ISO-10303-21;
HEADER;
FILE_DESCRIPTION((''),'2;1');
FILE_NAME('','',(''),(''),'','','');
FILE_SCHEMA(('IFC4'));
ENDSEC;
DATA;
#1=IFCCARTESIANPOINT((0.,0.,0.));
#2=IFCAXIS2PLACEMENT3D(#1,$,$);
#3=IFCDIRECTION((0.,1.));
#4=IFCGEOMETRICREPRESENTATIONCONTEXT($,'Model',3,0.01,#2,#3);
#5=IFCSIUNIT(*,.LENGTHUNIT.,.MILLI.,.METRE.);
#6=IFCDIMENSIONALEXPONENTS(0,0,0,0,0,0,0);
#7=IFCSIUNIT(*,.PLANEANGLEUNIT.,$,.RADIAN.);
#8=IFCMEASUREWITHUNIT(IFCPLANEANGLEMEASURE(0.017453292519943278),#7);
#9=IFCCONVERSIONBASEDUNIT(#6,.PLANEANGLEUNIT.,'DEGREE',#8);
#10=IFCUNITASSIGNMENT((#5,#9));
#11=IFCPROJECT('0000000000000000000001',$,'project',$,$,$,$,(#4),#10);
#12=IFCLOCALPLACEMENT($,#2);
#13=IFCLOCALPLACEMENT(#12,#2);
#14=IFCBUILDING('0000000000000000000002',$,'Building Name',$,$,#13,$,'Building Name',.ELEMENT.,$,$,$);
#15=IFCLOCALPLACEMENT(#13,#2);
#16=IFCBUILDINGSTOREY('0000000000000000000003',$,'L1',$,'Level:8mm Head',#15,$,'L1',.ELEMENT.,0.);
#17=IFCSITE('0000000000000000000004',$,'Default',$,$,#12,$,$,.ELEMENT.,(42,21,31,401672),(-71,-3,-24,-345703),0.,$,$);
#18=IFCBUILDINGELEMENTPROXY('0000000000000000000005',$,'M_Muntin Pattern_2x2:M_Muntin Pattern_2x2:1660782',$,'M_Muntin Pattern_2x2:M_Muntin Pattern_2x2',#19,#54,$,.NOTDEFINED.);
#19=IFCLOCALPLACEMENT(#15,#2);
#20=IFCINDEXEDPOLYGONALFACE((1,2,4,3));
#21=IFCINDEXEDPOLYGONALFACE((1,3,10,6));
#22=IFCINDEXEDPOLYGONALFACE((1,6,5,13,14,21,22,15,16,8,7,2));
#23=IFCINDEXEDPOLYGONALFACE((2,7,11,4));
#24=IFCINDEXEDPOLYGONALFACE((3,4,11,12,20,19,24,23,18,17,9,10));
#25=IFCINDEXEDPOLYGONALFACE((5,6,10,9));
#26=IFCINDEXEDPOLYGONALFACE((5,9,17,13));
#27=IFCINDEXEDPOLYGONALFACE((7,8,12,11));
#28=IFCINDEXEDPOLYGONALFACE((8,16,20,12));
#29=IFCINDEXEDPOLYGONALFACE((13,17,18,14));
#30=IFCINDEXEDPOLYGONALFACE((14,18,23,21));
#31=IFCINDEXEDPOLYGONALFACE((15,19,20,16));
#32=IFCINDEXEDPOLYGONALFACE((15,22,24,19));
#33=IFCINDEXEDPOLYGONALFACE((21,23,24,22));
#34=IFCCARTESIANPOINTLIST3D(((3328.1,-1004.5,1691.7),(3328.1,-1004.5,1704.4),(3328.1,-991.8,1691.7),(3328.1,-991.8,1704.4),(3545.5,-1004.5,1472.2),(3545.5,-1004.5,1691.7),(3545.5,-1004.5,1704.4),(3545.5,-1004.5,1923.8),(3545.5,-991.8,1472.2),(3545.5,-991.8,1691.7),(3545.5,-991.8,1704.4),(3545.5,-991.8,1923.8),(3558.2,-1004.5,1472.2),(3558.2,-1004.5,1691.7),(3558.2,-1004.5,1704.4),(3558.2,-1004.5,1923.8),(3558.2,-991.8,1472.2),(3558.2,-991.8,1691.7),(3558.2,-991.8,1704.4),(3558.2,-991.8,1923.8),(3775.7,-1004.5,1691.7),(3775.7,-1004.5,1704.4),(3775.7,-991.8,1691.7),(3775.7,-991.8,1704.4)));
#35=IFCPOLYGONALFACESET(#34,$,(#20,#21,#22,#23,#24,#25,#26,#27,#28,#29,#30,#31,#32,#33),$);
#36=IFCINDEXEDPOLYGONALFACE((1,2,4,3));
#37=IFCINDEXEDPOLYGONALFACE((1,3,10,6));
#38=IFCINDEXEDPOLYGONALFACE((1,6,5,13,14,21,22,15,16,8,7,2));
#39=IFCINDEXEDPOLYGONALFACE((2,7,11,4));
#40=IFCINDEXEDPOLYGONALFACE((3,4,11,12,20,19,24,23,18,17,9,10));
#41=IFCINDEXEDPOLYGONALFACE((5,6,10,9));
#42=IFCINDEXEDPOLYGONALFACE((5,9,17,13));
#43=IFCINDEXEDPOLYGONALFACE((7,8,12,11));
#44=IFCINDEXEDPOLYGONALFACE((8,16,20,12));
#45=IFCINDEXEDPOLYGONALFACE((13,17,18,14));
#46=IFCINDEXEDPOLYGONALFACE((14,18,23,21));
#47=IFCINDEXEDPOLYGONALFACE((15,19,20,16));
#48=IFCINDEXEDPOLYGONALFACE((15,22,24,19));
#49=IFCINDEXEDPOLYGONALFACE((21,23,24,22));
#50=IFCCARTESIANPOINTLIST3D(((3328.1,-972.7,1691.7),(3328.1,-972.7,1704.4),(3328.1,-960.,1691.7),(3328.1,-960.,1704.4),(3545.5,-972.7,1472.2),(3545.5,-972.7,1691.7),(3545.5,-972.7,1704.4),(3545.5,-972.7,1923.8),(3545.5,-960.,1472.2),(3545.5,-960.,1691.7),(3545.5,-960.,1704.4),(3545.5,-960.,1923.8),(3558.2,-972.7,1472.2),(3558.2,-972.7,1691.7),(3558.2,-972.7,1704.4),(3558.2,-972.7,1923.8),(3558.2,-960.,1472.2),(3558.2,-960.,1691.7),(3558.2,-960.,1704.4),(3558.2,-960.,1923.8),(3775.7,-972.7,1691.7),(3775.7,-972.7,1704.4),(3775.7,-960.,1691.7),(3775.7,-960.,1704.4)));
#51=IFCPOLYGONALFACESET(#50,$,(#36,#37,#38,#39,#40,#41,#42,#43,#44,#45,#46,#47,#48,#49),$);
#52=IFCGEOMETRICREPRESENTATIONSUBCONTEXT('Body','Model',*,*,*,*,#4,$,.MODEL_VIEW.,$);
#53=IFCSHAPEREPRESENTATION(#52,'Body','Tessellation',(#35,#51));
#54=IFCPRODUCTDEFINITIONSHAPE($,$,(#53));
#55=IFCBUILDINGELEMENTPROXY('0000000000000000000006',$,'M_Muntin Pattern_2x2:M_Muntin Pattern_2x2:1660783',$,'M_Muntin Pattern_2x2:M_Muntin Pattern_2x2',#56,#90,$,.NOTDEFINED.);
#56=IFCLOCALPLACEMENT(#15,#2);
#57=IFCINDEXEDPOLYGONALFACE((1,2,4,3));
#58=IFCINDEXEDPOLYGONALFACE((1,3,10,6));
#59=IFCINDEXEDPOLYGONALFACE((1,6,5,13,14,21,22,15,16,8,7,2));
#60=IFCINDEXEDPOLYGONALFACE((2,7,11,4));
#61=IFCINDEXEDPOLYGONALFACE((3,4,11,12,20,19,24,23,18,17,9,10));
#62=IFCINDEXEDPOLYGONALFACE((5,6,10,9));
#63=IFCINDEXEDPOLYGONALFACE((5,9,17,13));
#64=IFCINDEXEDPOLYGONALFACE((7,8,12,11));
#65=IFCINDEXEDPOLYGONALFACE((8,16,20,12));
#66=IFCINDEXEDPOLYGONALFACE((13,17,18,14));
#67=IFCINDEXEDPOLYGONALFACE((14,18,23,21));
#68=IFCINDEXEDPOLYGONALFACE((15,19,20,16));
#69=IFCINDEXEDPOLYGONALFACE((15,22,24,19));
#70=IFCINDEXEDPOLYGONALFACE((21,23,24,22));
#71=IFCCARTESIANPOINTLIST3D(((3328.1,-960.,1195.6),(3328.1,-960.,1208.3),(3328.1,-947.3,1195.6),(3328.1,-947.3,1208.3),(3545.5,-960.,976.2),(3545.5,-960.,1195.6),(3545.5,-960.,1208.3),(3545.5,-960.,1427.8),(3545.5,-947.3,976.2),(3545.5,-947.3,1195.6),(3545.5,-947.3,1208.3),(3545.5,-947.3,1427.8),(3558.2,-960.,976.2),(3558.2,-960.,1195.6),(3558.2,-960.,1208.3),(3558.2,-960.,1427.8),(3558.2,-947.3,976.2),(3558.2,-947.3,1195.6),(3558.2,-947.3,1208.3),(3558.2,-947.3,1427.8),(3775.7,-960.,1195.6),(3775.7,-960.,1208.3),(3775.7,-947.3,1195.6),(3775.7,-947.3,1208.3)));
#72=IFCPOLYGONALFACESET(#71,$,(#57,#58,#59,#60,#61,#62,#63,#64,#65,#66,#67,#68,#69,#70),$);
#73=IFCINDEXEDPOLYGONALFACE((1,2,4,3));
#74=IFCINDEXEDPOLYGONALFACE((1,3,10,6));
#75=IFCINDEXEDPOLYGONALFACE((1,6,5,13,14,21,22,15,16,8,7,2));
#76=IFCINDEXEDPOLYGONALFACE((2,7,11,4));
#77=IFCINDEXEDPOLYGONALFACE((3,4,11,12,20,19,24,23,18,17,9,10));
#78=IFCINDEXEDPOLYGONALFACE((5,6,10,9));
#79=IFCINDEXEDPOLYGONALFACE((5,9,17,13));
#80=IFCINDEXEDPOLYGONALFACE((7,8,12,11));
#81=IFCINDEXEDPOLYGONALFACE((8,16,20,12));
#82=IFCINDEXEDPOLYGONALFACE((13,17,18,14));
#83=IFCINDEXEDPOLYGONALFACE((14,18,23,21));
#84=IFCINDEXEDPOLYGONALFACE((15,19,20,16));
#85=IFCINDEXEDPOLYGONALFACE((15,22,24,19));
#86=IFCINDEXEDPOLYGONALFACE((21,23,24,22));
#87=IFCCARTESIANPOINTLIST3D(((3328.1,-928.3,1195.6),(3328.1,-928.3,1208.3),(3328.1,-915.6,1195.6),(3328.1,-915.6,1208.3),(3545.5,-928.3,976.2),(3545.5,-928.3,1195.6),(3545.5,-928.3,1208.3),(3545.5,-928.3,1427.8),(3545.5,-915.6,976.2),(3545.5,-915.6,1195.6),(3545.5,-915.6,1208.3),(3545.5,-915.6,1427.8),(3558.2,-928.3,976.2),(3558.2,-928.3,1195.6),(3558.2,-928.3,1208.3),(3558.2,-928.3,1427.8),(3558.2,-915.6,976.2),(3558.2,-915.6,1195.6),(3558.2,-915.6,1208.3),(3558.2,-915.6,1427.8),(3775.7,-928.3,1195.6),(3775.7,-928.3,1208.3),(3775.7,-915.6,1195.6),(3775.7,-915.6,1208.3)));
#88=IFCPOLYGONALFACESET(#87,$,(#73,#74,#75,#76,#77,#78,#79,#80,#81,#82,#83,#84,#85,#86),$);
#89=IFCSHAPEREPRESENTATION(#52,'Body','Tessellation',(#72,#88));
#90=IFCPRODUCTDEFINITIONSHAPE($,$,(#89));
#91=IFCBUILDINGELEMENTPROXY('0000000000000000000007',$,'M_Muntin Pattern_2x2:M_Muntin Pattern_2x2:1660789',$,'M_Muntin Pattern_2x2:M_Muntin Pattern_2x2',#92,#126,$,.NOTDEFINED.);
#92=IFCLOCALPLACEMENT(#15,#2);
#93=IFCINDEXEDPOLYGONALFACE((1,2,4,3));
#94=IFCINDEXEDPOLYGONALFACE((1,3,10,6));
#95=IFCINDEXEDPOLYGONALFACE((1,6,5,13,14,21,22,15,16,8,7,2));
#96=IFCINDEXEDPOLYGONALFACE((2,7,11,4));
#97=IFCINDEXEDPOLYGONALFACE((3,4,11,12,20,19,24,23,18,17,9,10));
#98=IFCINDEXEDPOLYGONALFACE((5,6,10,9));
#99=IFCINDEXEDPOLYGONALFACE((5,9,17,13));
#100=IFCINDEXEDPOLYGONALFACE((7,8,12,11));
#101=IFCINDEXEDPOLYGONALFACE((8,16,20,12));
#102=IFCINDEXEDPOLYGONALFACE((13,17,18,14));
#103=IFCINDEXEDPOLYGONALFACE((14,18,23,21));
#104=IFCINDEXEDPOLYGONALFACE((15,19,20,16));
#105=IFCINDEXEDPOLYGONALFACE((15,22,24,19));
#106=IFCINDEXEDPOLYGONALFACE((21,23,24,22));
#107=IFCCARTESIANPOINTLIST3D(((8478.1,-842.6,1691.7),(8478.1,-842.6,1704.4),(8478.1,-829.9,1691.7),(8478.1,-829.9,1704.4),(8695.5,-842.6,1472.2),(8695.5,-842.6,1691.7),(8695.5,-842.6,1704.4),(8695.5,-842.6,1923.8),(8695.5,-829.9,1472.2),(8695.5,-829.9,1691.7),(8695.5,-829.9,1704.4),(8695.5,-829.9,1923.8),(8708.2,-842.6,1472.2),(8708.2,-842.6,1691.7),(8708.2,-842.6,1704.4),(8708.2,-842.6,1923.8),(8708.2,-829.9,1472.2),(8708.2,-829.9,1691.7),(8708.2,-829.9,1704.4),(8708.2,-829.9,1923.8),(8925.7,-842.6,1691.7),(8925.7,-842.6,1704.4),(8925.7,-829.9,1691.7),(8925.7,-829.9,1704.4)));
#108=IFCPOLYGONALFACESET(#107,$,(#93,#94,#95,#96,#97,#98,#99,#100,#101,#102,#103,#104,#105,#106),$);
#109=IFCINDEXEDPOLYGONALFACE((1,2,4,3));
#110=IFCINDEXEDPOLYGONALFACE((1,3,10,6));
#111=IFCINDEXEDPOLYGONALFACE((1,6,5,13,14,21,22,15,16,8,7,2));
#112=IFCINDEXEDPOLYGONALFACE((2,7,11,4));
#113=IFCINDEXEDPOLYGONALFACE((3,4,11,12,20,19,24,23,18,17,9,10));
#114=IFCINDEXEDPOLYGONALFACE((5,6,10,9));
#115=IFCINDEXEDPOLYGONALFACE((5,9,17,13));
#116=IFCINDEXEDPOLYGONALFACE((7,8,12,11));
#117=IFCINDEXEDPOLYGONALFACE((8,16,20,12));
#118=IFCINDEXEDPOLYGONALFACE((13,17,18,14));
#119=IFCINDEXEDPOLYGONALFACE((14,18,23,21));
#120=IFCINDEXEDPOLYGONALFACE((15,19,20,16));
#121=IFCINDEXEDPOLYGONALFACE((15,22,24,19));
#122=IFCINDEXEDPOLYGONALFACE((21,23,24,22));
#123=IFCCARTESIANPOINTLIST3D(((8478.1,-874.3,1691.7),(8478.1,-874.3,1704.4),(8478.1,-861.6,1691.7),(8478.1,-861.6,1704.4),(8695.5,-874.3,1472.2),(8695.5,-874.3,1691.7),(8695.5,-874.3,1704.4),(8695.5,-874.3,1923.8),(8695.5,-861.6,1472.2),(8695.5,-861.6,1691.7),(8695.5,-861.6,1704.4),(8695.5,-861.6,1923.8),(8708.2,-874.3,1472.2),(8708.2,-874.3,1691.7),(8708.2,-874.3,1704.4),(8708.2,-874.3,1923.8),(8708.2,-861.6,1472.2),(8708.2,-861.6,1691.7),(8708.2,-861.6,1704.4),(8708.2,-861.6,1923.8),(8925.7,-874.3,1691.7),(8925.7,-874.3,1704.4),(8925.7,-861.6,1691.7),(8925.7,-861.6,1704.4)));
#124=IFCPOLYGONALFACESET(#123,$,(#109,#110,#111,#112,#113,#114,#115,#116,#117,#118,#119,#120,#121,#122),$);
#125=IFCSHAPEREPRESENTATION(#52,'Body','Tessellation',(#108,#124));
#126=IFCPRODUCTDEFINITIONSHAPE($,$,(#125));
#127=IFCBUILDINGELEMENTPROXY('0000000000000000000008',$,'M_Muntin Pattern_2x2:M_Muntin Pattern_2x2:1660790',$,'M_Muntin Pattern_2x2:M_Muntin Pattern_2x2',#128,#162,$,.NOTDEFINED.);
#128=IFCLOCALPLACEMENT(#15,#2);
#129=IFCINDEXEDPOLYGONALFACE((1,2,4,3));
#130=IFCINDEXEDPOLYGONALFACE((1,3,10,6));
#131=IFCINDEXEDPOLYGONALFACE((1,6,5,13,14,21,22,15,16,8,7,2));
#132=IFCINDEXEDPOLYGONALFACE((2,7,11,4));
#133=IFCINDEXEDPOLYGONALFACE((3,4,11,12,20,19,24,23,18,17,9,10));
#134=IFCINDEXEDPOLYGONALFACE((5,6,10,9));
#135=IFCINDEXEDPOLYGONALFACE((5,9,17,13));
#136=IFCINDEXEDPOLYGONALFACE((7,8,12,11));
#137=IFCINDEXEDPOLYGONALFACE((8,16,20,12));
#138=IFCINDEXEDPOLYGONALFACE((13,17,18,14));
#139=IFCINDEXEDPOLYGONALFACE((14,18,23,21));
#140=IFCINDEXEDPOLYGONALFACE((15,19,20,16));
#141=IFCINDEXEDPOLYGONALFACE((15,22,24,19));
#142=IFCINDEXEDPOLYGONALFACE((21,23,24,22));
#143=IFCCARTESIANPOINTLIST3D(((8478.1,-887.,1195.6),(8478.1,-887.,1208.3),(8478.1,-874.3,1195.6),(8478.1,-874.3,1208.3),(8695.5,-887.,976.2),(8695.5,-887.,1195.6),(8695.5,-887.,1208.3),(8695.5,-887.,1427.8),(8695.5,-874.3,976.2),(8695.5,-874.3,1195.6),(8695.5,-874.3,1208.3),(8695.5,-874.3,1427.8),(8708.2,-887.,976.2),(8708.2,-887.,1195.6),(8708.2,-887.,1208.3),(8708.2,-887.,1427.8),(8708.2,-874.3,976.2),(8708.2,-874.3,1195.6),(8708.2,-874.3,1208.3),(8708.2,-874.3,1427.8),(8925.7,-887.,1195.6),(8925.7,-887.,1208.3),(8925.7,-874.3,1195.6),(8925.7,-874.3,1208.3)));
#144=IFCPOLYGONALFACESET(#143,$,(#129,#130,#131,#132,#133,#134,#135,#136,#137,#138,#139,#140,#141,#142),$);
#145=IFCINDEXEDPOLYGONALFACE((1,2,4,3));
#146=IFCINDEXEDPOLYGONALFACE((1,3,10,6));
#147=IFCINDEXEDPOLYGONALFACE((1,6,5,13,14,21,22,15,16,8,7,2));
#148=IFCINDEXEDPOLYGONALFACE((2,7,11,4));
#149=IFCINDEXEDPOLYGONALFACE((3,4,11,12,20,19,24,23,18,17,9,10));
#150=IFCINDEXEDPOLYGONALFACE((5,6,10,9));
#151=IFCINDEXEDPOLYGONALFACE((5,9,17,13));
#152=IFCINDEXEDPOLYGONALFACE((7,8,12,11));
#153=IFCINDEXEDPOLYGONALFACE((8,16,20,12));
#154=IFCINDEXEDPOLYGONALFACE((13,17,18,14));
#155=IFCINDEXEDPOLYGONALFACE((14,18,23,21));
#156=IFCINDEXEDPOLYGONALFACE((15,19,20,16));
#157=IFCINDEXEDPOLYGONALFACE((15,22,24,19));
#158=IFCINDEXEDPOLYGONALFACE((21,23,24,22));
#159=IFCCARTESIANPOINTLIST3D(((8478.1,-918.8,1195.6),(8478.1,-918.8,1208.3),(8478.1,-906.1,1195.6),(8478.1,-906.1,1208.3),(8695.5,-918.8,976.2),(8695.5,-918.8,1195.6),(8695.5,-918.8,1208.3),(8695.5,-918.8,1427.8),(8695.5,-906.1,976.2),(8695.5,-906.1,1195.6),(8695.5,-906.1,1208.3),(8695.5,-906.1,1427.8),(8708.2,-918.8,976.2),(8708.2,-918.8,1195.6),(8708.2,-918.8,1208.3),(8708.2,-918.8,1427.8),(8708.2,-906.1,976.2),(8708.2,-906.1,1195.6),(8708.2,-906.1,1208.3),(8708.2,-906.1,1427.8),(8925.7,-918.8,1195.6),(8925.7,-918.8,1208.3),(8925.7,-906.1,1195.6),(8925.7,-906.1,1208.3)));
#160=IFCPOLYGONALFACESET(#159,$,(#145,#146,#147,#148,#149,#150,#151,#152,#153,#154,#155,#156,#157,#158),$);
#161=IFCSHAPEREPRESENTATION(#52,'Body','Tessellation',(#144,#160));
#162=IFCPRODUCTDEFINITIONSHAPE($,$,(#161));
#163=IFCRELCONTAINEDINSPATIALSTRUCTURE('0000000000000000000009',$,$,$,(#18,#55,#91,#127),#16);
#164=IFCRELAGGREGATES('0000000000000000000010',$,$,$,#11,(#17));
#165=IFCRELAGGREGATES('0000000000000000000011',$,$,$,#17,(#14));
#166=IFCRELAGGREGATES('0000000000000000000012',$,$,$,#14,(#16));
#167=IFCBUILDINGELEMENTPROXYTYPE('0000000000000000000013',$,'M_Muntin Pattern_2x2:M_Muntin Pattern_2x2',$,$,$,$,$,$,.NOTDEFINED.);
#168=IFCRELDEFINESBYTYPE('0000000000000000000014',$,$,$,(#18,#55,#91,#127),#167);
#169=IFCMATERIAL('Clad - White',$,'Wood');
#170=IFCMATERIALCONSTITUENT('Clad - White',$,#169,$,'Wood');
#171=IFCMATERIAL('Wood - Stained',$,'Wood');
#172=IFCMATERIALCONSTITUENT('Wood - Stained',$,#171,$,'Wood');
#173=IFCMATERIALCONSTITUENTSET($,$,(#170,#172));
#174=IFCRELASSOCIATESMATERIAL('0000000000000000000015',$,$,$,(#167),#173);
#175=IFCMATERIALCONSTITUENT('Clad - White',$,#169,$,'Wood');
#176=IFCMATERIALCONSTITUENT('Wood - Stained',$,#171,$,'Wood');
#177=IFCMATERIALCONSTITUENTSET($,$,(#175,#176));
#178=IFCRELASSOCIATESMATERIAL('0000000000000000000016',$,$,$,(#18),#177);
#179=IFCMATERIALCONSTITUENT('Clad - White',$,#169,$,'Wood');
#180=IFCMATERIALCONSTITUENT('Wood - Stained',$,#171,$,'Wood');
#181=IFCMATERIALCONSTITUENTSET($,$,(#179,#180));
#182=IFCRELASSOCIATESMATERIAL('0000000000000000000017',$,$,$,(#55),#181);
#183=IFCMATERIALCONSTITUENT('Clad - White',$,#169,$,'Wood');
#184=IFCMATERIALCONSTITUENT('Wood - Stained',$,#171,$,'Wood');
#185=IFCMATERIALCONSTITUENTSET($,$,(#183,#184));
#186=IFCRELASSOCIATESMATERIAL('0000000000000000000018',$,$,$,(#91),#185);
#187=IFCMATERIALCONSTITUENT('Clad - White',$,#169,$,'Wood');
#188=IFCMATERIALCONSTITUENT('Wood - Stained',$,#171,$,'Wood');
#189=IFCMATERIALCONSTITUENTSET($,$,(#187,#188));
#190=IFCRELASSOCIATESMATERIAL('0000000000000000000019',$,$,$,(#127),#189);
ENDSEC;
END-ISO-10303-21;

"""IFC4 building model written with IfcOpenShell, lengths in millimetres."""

from ifc_helpers import new_model, entity, si_unit, converted_unit, direction, frame, origin, place, context, subcontext, project, spatial, indexed_curve, outline, extrude, source, transform, mapped, material, constituent, constituent_set, type_object, type_shapes, element, save


model = new_model("IFC4")

# Units and contexts
model_context = context("Model", 3, precision=0.01, world=origin(), true_north=direction((0.0, 1.0)))
body_context = subcontext(model_context, "Body", "Model", "MODEL_VIEW")
ifc_project = project(units=[si_unit("LENGTHUNIT", "METRE", prefix="MILLI"), converted_unit("PLANEANGLEUNIT", "DEGREE", entity("IfcPlaneAngleMeasure", 0.017453292519943278), si_unit("PLANEANGLEUNIT", "RADIAN"), dimensions=[0, 0, 0, 0, 0, 0, 0])], contexts=[model_context])

# Site, building, storey
site_placement = place(None, origin())
site = spatial("IfcSite", under=ifc_project, at=site_placement, Name="Default", CompositionType="ELEMENT", RefLatitude=(42, 21, 31, 401672), RefLongitude=(-71, -3, -24, -345703), RefElevation=0.0)
building_placement = place(site_placement, origin())
building = spatial("IfcBuilding", under=site, at=building_placement, Name="Building Name", LongName="Building Name", CompositionType="ELEMENT")
storey_placement = place(building_placement, origin())
storey = spatial("IfcBuildingStorey", under=building, at=storey_placement, Name="L1", ObjectType="Level:8mm Head", LongName="L1", CompositionType="ELEMENT", Elevation=0.0)

# Building element proxies
ifc_material_1 = material(Name="Clad - White", Category="Wood")
ifc_material_2 = material(Name="Wood - Stained", Category="Wood")
ifc_constituent_1 = constituent(ifc_material_1, Name="Clad - White", Category="Wood")
ifc_constituent_2 = constituent(ifc_material_2, Name="Wood - Stained", Category="Wood")
ifc_constituent_set_1 = constituent_set(constituents=[ifc_constituent_1, ifc_constituent_2])
ifc_constituent_3 = constituent(ifc_material_1, Name="Clad - White", Category="Wood")
ifc_constituent_4 = constituent(ifc_material_2, Name="Wood - Stained", Category="Wood")
ifc_constituent_set_2 = constituent_set(constituents=[ifc_constituent_3, ifc_constituent_4])
building_element_proxy_type_1 = type_object("IfcBuildingElementProxyType", Name="M_Muntin Pattern_2x2:M_Muntin Pattern_2x2", PredefinedType="NOTDEFINED", material=ifc_constituent_set_2)
shared_shape_1 = source(origin(), body_context, "Body", "SweptSolid", [
    extrude(outline(indexed_curve([(6.4, -6.4), (225.8, -6.4), (225.8, 6.3), (6.4, 6.3), (6.4, 223.8), (-6.3, 223.8), (-6.3, 6.3), (-225.8, 6.3), (-225.8, -6.4), (-6.3, -6.4), (-6.3, -223.8), (6.4, -223.8), (6.4, -6.4)], self_intersect=False)), frame((0.0, 9.5, 225.8), z_axis=(0.0, 1.0, 0.0), x_axis=(0.0, 0.0, 1.0)), (0.0, 0.0, 1.0), 12.7),
    extrude(outline(indexed_curve([(6.4, -6.4), (225.8, -6.4), (225.8, 6.3), (6.4, 6.3), (6.4, 223.8), (-6.3, 223.8), (-6.3, 6.3), (-225.8, 6.3), (-225.8, -6.4), (-6.3, -6.4), (-6.3, -223.8), (6.4, -223.8), (6.4, -6.4)], self_intersect=False)), frame((0.0, -22.2, 225.8), z_axis=(0.0, 1.0, 0.0), x_axis=(0.0, 0.0, 1.0)), (0.0, 0.0, 1.0), 12.7),
])
type_shapes(building_element_proxy_type_1, [shared_shape_1])
proxy_1_placement = place(storey_placement, frame((3551.9, -982.3, 1472.2), z_axis=(0.0, 0.0, 1.0), x_axis=(-1.0, 0.0, 0.0)))
element("IfcBuildingElementProxy", 1, at=proxy_1_placement, inside=storey, type_object=building_element_proxy_type_1, material=ifc_constituent_set_1, Name="M_Muntin Pattern_2x2:M_Muntin Pattern_2x2:1660782", ObjectType="M_Muntin Pattern_2x2:M_Muntin Pattern_2x2", PredefinedType="NOTDEFINED", context=body_context, shape_type="MappedRepresentation", body=[
    mapped(shared_shape_1, transform((0.0, 0.0, 0.0), scale=1.0)),
])
ifc_constituent_5 = constituent(ifc_material_1, Name="Clad - White", Category="Wood")
ifc_constituent_6 = constituent(ifc_material_2, Name="Wood - Stained", Category="Wood")
ifc_constituent_set_3 = constituent_set(constituents=[ifc_constituent_5, ifc_constituent_6])
proxy_2_placement = place(storey_placement, frame((3551.9, -937.8, 976.2), z_axis=(0.0, 0.0, 1.0), x_axis=(-1.0, 0.0, 0.0)))
element("IfcBuildingElementProxy", 2, at=proxy_2_placement, inside=storey, type_object=building_element_proxy_type_1, material=ifc_constituent_set_3, Name="M_Muntin Pattern_2x2:M_Muntin Pattern_2x2:1660783", ObjectType="M_Muntin Pattern_2x2:M_Muntin Pattern_2x2", PredefinedType="NOTDEFINED", context=body_context, shape_type="MappedRepresentation", body=[
    mapped(shared_shape_1, transform((0.0, 0.0, 0.0), scale=1.0)),
])
ifc_constituent_7 = constituent(ifc_material_1, Name="Clad - White", Category="Wood")
ifc_constituent_8 = constituent(ifc_material_2, Name="Wood - Stained", Category="Wood")
ifc_constituent_set_4 = constituent_set(constituents=[ifc_constituent_7, ifc_constituent_8])
proxy_3_placement = place(storey_placement, frame((8701.9, -852.1, 1472.2)))
element("IfcBuildingElementProxy", 3, at=proxy_3_placement, inside=storey, type_object=building_element_proxy_type_1, material=ifc_constituent_set_4, Name="M_Muntin Pattern_2x2:M_Muntin Pattern_2x2:1660789", ObjectType="M_Muntin Pattern_2x2:M_Muntin Pattern_2x2", PredefinedType="NOTDEFINED", context=body_context, shape_type="MappedRepresentation", body=[
    mapped(shared_shape_1, transform((0.0, 0.0, 0.0), scale=1.0)),
])
ifc_constituent_9 = constituent(ifc_material_1, Name="Clad - White", Category="Wood")
ifc_constituent_10 = constituent(ifc_material_2, Name="Wood - Stained", Category="Wood")
ifc_constituent_set_5 = constituent_set(constituents=[ifc_constituent_9, ifc_constituent_10])
proxy_4_placement = place(storey_placement, frame((8701.9, -896.6, 976.2)))
element("IfcBuildingElementProxy", 4, at=proxy_4_placement, inside=storey, type_object=building_element_proxy_type_1, material=ifc_constituent_set_5, Name="M_Muntin Pattern_2x2:M_Muntin Pattern_2x2:1660790", ObjectType="M_Muntin Pattern_2x2:M_Muntin Pattern_2x2", PredefinedType="NOTDEFINED", context=body_context, shape_type="MappedRepresentation", body=[
    mapped(shared_shape_1, transform((0.0, 0.0, 0.0), scale=1.0)),
])

save(model, "model.ifc")
